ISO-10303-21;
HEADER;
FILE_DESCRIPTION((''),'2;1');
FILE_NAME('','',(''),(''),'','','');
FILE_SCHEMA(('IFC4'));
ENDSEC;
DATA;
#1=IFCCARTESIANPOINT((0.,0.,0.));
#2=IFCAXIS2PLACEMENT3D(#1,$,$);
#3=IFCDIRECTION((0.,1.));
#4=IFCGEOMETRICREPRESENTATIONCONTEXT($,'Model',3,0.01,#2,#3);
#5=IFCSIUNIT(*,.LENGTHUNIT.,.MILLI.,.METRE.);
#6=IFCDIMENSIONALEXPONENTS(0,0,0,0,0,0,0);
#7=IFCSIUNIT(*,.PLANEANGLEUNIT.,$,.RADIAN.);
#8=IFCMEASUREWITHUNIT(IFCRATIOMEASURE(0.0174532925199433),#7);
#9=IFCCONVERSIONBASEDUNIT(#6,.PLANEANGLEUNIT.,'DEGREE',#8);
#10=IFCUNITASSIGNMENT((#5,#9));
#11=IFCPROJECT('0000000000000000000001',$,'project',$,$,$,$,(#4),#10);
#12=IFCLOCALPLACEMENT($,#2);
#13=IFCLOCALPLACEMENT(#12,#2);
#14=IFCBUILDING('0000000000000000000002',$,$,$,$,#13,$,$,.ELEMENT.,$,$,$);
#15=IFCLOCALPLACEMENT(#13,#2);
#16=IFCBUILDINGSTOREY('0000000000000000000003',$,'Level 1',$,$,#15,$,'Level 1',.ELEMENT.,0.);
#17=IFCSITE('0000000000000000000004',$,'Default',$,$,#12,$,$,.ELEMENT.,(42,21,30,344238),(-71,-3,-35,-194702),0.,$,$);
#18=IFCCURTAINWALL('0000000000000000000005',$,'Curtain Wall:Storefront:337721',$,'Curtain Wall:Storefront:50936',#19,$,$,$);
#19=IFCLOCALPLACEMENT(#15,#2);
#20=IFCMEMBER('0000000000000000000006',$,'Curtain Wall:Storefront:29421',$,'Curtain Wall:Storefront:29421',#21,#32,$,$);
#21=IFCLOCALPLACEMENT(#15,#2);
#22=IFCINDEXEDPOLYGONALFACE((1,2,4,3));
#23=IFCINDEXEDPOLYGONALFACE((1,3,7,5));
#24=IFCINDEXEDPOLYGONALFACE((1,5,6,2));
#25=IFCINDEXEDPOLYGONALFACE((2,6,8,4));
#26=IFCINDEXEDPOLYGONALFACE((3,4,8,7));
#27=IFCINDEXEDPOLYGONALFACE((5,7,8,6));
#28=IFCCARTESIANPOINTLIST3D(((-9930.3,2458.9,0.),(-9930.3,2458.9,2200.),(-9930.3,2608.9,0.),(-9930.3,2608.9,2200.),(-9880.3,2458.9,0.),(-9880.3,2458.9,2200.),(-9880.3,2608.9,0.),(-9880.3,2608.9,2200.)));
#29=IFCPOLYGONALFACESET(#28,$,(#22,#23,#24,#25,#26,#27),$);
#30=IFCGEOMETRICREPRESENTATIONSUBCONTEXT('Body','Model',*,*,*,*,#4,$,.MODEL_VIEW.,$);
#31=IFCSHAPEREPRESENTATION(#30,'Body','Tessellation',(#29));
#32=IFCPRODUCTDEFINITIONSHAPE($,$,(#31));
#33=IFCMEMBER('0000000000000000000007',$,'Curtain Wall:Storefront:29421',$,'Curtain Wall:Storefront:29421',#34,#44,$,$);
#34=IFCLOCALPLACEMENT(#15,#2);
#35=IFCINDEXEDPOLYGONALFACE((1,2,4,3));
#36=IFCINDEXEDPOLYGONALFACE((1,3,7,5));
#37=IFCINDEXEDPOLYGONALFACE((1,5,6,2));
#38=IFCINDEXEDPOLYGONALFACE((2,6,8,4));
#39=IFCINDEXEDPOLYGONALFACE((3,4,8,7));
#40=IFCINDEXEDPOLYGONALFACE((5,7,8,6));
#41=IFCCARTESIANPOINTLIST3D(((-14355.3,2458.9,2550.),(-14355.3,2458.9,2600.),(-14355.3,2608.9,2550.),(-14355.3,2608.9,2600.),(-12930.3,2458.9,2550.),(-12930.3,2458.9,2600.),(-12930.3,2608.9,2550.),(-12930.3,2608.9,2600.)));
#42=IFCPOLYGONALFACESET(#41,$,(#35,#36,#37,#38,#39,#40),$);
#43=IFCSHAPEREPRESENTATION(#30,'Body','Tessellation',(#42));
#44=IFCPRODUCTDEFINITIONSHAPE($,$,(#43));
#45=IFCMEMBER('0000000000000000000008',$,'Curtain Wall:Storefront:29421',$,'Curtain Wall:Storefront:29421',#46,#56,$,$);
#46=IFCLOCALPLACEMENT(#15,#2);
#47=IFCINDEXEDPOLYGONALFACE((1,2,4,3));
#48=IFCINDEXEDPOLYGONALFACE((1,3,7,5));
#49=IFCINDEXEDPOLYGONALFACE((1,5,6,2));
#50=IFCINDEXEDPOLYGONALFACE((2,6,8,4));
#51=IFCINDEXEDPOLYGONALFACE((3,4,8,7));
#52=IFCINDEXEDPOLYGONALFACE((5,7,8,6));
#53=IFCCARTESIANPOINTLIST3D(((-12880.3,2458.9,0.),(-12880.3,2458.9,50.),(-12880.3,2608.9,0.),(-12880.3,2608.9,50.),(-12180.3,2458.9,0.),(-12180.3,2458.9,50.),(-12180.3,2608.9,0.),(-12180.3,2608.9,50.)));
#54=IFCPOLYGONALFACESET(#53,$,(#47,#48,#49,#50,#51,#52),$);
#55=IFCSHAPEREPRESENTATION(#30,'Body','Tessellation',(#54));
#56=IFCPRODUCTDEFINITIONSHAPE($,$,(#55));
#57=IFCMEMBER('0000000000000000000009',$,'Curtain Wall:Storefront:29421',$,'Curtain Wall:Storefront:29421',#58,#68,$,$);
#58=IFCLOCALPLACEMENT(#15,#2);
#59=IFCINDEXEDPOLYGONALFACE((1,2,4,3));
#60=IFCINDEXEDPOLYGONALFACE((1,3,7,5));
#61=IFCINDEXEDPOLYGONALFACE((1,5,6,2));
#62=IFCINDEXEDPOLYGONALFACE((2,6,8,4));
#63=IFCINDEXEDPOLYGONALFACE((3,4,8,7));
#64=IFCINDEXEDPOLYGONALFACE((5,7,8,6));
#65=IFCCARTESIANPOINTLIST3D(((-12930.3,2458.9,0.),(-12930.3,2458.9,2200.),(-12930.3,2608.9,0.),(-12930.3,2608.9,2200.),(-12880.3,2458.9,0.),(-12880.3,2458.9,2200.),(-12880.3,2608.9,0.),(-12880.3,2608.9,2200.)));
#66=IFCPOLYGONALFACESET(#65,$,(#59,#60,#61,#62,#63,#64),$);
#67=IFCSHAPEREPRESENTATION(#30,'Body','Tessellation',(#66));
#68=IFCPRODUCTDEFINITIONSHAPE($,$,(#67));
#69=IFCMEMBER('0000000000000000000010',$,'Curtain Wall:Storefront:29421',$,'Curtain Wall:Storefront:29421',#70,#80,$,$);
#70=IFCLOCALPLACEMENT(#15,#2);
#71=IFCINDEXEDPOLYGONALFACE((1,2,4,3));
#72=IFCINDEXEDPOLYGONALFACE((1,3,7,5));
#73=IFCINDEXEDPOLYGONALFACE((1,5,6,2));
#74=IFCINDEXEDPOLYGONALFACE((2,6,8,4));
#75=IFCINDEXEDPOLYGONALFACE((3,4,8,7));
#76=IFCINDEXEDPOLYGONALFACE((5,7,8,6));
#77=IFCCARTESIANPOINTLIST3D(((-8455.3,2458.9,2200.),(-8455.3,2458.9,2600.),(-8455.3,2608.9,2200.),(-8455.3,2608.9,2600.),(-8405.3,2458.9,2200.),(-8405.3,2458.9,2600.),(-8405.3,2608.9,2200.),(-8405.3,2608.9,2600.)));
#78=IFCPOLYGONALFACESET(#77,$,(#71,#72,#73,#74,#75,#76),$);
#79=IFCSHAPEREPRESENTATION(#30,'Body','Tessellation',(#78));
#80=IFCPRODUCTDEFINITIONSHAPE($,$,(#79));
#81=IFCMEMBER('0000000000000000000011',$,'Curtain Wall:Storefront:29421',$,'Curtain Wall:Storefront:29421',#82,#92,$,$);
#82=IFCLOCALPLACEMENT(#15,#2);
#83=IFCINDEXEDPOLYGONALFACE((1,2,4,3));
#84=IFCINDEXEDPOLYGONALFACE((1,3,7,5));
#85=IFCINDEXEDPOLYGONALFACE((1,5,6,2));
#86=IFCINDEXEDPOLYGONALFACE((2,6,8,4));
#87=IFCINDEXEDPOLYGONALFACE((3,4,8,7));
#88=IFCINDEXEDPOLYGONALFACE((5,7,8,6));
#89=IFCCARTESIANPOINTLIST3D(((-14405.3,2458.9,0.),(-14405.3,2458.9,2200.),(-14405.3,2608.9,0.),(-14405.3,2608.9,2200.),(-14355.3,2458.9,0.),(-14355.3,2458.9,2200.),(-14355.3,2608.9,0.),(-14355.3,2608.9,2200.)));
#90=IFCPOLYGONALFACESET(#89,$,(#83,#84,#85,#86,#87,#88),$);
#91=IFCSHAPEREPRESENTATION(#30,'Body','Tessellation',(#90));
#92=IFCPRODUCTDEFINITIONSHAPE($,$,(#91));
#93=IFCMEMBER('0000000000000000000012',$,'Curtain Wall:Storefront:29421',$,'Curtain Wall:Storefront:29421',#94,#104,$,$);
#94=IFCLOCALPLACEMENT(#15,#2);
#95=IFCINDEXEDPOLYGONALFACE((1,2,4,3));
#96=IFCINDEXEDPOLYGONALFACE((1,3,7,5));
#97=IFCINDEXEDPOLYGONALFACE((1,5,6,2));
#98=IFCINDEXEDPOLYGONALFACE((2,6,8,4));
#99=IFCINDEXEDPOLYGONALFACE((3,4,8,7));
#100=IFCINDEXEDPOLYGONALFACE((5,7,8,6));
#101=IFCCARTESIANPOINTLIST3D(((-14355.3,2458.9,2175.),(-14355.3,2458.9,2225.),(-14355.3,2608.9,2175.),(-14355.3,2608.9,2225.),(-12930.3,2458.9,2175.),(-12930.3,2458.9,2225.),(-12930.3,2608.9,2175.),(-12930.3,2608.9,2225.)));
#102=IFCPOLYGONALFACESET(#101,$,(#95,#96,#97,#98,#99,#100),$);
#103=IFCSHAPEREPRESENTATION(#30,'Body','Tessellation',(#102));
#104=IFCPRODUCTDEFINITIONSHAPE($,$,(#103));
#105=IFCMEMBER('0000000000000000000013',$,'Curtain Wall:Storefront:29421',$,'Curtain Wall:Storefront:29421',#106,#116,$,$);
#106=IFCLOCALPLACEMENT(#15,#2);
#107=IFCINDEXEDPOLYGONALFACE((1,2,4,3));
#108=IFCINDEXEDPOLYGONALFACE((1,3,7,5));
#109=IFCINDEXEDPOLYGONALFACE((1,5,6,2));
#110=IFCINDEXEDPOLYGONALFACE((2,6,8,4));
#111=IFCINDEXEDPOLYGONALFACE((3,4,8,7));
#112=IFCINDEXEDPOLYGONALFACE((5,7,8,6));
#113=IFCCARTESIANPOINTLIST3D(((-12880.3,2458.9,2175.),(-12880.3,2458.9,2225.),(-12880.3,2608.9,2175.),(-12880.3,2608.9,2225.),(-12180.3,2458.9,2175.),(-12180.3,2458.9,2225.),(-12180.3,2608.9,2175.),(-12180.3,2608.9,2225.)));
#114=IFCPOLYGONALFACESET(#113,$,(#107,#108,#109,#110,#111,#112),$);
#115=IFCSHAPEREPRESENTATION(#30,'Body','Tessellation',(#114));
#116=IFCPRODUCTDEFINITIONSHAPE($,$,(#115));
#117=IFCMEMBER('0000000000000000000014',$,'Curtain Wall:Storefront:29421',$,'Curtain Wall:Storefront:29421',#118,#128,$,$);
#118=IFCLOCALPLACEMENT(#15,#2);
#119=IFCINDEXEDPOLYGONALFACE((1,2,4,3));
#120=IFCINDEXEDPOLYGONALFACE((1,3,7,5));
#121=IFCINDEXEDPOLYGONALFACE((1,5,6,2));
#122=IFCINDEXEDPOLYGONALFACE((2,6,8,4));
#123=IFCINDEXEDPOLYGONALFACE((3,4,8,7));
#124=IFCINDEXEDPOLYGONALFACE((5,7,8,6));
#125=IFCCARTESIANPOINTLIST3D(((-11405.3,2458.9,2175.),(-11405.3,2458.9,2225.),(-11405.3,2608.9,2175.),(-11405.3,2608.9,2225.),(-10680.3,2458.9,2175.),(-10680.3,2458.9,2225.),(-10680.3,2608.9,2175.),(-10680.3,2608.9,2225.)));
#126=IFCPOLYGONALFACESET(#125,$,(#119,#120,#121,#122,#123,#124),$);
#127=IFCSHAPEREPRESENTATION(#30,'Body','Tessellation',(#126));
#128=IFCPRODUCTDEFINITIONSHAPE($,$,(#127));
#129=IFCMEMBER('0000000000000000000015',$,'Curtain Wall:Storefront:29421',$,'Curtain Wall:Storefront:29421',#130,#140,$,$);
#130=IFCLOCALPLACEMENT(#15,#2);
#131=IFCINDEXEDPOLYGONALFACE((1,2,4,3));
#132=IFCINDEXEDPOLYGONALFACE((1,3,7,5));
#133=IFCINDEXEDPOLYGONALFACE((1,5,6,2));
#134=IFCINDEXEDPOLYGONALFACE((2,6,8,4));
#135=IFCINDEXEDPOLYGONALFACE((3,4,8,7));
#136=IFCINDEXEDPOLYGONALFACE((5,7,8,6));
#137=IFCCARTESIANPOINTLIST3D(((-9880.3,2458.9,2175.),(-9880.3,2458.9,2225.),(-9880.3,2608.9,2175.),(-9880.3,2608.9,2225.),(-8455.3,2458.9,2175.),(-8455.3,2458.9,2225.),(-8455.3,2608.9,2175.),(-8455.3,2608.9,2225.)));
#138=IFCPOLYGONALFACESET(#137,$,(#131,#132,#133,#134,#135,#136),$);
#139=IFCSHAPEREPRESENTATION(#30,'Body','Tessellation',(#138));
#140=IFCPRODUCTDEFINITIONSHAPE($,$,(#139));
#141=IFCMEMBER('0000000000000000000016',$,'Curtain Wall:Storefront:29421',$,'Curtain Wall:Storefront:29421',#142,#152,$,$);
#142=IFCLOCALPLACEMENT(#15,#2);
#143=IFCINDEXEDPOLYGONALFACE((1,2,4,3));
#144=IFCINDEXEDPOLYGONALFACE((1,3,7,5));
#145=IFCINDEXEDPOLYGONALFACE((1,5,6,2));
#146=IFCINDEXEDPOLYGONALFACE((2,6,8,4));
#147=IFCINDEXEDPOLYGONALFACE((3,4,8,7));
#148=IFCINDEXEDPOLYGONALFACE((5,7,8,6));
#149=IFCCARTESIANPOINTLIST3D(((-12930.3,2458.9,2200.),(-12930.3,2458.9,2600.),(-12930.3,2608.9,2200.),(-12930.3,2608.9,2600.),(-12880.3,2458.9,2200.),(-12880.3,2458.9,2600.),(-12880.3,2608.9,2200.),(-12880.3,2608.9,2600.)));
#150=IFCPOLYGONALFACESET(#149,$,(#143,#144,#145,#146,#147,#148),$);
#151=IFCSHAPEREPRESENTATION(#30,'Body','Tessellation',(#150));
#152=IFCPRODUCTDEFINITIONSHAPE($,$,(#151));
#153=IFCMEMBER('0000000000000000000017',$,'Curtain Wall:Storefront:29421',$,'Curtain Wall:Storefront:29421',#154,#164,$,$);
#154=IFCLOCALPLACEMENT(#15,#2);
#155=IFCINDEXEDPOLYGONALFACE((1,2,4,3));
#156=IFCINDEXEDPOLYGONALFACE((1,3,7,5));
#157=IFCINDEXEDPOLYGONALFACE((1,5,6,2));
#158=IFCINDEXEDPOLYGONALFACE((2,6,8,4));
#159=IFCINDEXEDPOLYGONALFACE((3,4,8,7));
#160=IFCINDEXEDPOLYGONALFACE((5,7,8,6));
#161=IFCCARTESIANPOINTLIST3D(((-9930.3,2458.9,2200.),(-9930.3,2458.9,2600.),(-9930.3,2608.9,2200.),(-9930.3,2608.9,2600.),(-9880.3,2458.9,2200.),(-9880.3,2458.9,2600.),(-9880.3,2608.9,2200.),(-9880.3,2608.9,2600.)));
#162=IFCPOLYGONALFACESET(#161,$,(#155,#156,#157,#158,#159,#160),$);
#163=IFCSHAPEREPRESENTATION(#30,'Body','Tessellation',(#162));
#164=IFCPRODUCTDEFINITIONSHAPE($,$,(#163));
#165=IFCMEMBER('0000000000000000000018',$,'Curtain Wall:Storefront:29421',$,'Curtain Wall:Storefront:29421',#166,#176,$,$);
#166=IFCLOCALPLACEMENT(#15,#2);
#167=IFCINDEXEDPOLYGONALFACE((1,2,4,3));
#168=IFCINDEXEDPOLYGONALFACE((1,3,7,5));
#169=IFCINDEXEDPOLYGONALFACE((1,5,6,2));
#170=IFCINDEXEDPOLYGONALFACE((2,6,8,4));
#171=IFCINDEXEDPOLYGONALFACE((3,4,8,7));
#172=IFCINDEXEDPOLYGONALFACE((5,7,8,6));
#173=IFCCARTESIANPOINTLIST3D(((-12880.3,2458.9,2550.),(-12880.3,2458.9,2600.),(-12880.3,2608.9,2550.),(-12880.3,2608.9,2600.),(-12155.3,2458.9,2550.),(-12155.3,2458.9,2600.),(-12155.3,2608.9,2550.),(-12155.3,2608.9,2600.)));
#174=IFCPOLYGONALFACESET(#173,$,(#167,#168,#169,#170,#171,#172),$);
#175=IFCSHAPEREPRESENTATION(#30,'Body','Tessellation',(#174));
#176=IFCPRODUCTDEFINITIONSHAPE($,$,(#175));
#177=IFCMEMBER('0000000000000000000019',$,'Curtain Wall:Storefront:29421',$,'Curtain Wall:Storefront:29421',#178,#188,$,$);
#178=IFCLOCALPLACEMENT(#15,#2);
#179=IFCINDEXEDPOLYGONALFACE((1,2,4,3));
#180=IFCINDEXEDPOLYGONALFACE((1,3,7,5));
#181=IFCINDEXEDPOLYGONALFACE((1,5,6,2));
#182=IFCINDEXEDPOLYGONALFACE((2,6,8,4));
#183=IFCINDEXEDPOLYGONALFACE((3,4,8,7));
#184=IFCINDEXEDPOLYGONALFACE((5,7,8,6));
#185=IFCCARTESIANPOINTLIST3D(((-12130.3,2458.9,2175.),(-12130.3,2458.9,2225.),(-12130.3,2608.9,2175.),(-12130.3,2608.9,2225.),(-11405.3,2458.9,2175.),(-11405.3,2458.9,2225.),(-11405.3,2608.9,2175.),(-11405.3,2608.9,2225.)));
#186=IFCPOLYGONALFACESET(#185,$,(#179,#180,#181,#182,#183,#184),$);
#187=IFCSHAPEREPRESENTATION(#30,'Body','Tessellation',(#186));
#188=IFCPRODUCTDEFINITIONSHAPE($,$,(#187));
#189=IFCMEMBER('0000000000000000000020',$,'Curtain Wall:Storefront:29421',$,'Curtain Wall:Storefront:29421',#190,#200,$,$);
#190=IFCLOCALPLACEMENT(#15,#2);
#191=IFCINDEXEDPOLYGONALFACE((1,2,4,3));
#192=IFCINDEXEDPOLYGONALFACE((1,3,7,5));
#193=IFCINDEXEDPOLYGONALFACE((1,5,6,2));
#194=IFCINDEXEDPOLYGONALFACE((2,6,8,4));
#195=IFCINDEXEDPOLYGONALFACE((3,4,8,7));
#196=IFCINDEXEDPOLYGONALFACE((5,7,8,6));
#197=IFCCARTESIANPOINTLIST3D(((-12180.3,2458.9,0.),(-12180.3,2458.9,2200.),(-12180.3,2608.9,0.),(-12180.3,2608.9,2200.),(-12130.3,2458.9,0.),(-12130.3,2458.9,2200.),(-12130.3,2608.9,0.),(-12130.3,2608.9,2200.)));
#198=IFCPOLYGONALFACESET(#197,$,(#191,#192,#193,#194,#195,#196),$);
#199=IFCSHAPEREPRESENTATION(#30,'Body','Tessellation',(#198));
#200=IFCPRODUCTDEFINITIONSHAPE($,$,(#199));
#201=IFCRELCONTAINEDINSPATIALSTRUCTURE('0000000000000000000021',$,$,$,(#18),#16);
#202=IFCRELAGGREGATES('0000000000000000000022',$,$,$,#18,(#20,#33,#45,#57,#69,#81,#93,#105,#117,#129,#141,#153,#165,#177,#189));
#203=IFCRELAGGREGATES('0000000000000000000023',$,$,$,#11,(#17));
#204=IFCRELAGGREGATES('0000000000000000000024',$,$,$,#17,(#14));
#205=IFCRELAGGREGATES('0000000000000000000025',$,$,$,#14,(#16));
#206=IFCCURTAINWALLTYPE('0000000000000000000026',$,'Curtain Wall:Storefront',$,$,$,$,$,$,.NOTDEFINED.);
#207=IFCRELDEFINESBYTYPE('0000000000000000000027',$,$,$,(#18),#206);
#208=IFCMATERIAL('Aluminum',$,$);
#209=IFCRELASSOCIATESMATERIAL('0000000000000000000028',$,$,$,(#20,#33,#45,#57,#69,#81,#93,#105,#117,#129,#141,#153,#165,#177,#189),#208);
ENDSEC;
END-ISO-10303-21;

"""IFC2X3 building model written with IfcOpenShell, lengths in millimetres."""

from ifc_helpers import new_model, entity, si_unit, converted_unit, direction, frame, frame_2d, origin, origin_2d_with_axis, place, context, subcontext, project, spatial, rectangle, extrude, material, type_object, element, aggregate, save


model = new_model("IFC2X3")

# Units and contexts
model_context = context("Model", 3, precision=0.01, world=origin(), true_north=direction((0.0, 1.0)))
body_context = subcontext(model_context, "Body", "Model", "MODEL_VIEW")
ifc_project = project(units=[si_unit("LENGTHUNIT", "METRE", prefix="MILLI"), converted_unit("PLANEANGLEUNIT", "DEGREE", entity("IfcRatioMeasure", 0.0174532925199433), si_unit("PLANEANGLEUNIT", "RADIAN"), dimensions=[0, 0, 0, 0, 0, 0, 0])], contexts=[model_context])

# Site, building, storey
site_placement = place(None, origin())
site = spatial("IfcSite", under=ifc_project, at=site_placement, Name="Default", CompositionType="ELEMENT", RefLatitude=(42, 21, 30, 344238), RefLongitude=(-71, -3, -35, -194702), RefElevation=0.0)
building_placement = place(site_placement, origin())
building = spatial("IfcBuilding", under=site, at=building_placement, CompositionType="ELEMENT")
storey_placement = place(building_placement, origin())
storey = spatial("IfcBuildingStorey", under=building, at=storey_placement, Name="Level 1", LongName="Level 1", CompositionType="ELEMENT", Elevation=0.0)

# Curtain wall, members
curtain_wall_type = type_object("IfcCurtainWallType", Name="Curtain Wall:Storefront", PredefinedType="NOTDEFINED")
curtain_wall_placement = place(storey_placement, origin())
curtain_wall = element("IfcCurtainWall", 1, at=curtain_wall_placement, inside=storey, type_object=curtain_wall_type, Name="Curtain Wall:Storefront:337721", ObjectType="Curtain Wall:Storefront:50936")
ifc_material = material(Name="Aluminum")
member_1_placement = place(curtain_wall_placement, origin())
member_1 = element("IfcMember", 2, at=member_1_placement, material=ifc_material, Name="Curtain Wall:Storefront:29421", ObjectType="Curtain Wall:Storefront:29421", context=body_context, shape_type="SweptSolid", body=[
    extrude(rectangle(XDim=50.0, YDim=150.0, at=origin_2d_with_axis()), frame((-9905.3, 2533.9, 0.0), z_axis=(0.0, 0.0, 1.0), x_axis=(-1.0, 0.0, 0.0)), (0.0, 0.0, 1.0), 2200.0),
])
member_2_placement = place(curtain_wall_placement, origin())
member_2 = element("IfcMember", 3, at=member_2_placement, material=ifc_material, Name="Curtain Wall:Storefront:29421", ObjectType="Curtain Wall:Storefront:29421", context=body_context, shape_type="SweptSolid", body=[
    extrude(rectangle(XDim=50.0, YDim=150.0, at=frame_2d((0.0, 0.0), x_axis=(1.0, 0.0))), frame((-12930.3, 2533.9, 2575.0), z_axis=(-1.0, 0.0, 0.0), x_axis=(0.0, 0.0, -1.0)), (0.0, 0.0, 1.0), 1425.0),
])
member_3_placement = place(curtain_wall_placement, origin())
member_3 = element("IfcMember", 4, at=member_3_placement, material=ifc_material, Name="Curtain Wall:Storefront:29421", ObjectType="Curtain Wall:Storefront:29421", context=body_context, shape_type="SweptSolid", body=[
    extrude(rectangle(XDim=50.0, YDim=150.0, at=frame_2d((0.0, 0.0), x_axis=(1.0, 0.0))), frame((-12880.3, 2533.9, 25.0), z_axis=(1.0, 0.0, 0.0), x_axis=(0.0, 0.0, -1.0)), (0.0, 0.0, 1.0), 700.0),
])
member_4_placement = place(curtain_wall_placement, origin())
member_4 = element("IfcMember", 5, at=member_4_placement, material=ifc_material, Name="Curtain Wall:Storefront:29421", ObjectType="Curtain Wall:Storefront:29421", context=body_context, shape_type="SweptSolid", body=[
    extrude(rectangle(XDim=50.0, YDim=150.0, at=origin_2d_with_axis()), frame((-12905.3, 2533.9, 0.0), z_axis=(0.0, 0.0, 1.0), x_axis=(-1.0, 0.0, 0.0)), (0.0, 0.0, 1.0), 2200.0),
])
member_5_placement = place(curtain_wall_placement, origin())
member_5 = element("IfcMember", 6, at=member_5_placement, material=ifc_material, Name="Curtain Wall:Storefront:29421", ObjectType="Curtain Wall:Storefront:29421", context=body_context, shape_type="SweptSolid", body=[
    extrude(rectangle(XDim=50.0, YDim=150.0, at=origin_2d_with_axis()), frame((-8430.3, 2533.9, 2200.0), z_axis=(0.0, 0.0, 1.0), x_axis=(-1.0, 0.0, 0.0)), (0.0, 0.0, 1.0), 400.0),
])
member_6_placement = place(curtain_wall_placement, origin())
member_6 = element("IfcMember", 7, at=member_6_placement, material=ifc_material, Name="Curtain Wall:Storefront:29421", ObjectType="Curtain Wall:Storefront:29421", context=body_context, shape_type="SweptSolid", body=[
    extrude(rectangle(XDim=50.0, YDim=150.0, at=frame_2d((0.0, 0.0), x_axis=(1.0, 0.0))), frame((-14380.3, 2533.9, 2200.0), z_axis=(0.0, 0.0, -1.0), x_axis=(-1.0, 0.0, 0.0)), (0.0, 0.0, 1.0), 2200.0),
])
member_7_placement = place(curtain_wall_placement, origin())
member_7 = element("IfcMember", 8, at=member_7_placement, material=ifc_material, Name="Curtain Wall:Storefront:29421", ObjectType="Curtain Wall:Storefront:29421", context=body_context, shape_type="SweptSolid", body=[
    extrude(rectangle(XDim=50.0, YDim=150.0, at=frame_2d((0.0, 0.0), x_axis=(1.0, 0.0))), frame((-12930.3, 2533.9, 2200.0), z_axis=(-1.0, 0.0, 0.0), x_axis=(0.0, 0.0, -1.0)), (0.0, 0.0, 1.0), 1425.0),
])
member_8_placement = place(curtain_wall_placement, origin())
member_8 = element("IfcMember", 9, at=member_8_placement, material=ifc_material, Name="Curtain Wall:Storefront:29421", ObjectType="Curtain Wall:Storefront:29421", context=body_context, shape_type="SweptSolid", body=[
    extrude(rectangle(XDim=50.0, YDim=150.0, at=frame_2d((0.0, 0.0), x_axis=(1.0, 0.0))), frame((-12180.3, 2533.9, 2200.0), z_axis=(-1.0, 0.0, 0.0), x_axis=(0.0, 0.0, -1.0)), (0.0, 0.0, 1.0), 700.0),
])
member_9_placement = place(curtain_wall_placement, origin())
member_9 = element("IfcMember", 10, at=member_9_placement, material=ifc_material, Name="Curtain Wall:Storefront:29421", ObjectType="Curtain Wall:Storefront:29421", context=body_context, shape_type="SweptSolid", body=[
    extrude(rectangle(XDim=50.0, YDim=150.0, at=frame_2d((0.0, 0.0), x_axis=(1.0, 0.0))), frame((-10680.3, 2533.9, 2200.0), z_axis=(-1.0, 0.0, 0.0), x_axis=(0.0, 0.0, -1.0)), (0.0, 0.0, 1.0), 725.0),
])
member_10_placement = place(curtain_wall_placement, origin())
member_10 = element("IfcMember", 11, at=member_10_placement, material=ifc_material, Name="Curtain Wall:Storefront:29421", ObjectType="Curtain Wall:Storefront:29421", context=body_context, shape_type="SweptSolid", body=[
    extrude(rectangle(XDim=50.0, YDim=150.0, at=frame_2d((0.0, 0.0), x_axis=(1.0, 0.0))), frame((-8455.3, 2533.9, 2200.0), z_axis=(-1.0, 0.0, 0.0), x_axis=(0.0, 0.0, -1.0)), (0.0, 0.0, 1.0), 1425.0),
])
member_11_placement = place(curtain_wall_placement, origin())
member_11 = element("IfcMember", 12, at=member_11_placement, material=ifc_material, Name="Curtain Wall:Storefront:29421", ObjectType="Curtain Wall:Storefront:29421", context=body_context, shape_type="SweptSolid", body=[
    extrude(rectangle(XDim=50.0, YDim=150.0, at=origin_2d_with_axis()), frame((-12905.3, 2533.9, 2200.0), z_axis=(0.0, 0.0, 1.0), x_axis=(-1.0, 0.0, 0.0)), (0.0, 0.0, 1.0), 400.0),
])
member_12_placement = place(curtain_wall_placement, origin())
member_12 = element("IfcMember", 13, at=member_12_placement, material=ifc_material, Name="Curtain Wall:Storefront:29421", ObjectType="Curtain Wall:Storefront:29421", context=body_context, shape_type="SweptSolid", body=[
    extrude(rectangle(XDim=50.0, YDim=150.0, at=origin_2d_with_axis()), frame((-9905.3, 2533.9, 2200.0), z_axis=(0.0, 0.0, 1.0), x_axis=(-1.0, 0.0, 0.0)), (0.0, 0.0, 1.0), 400.0),
])
member_13_placement = place(curtain_wall_placement, origin())
member_13 = element("IfcMember", 14, at=member_13_placement, material=ifc_material, Name="Curtain Wall:Storefront:29421", ObjectType="Curtain Wall:Storefront:29421", context=body_context, shape_type="SweptSolid", body=[
    extrude(rectangle(XDim=50.0, YDim=150.0, at=frame_2d((0.0, 0.0), x_axis=(1.0, 0.0))), frame((-12155.3, 2533.9, 2575.0), z_axis=(-1.0, 0.0, 0.0), x_axis=(0.0, 0.0, -1.0)), (0.0, 0.0, 1.0), 725.0),
])
member_14_placement = place(curtain_wall_placement, origin())
member_14 = element("IfcMember", 15, at=member_14_placement, material=ifc_material, Name="Curtain Wall:Storefront:29421", ObjectType="Curtain Wall:Storefront:29421", context=body_context, shape_type="SweptSolid", body=[
    extrude(rectangle(XDim=50.0, YDim=150.0, at=frame_2d((0.0, 0.0), x_axis=(1.0, 0.0))), frame((-11405.3, 2533.9, 2200.0), z_axis=(-1.0, 0.0, 0.0), x_axis=(0.0, 0.0, -1.0)), (0.0, 0.0, 1.0), 725.0),
])
member_15_placement = place(curtain_wall_placement, origin())
member_15 = element("IfcMember", 16, at=member_15_placement, material=ifc_material, Name="Curtain Wall:Storefront:29421", ObjectType="Curtain Wall:Storefront:29421", context=body_context, shape_type="SweptSolid", body=[
    extrude(rectangle(XDim=50.0, YDim=150.0, at=frame_2d((0.0, 0.0), x_axis=(1.0, 0.0))), frame((-12155.3, 2533.9, 0.0), z_axis=(0.0, 0.0, 1.0), x_axis=(-1.0, 0.0, 0.0)), (0.0, 0.0, 1.0), 2200.0),
])
aggregate(curtain_wall, [member_1, member_2, member_3, member_4, member_5, member_6, member_7, member_8, member_9, member_10, member_11, member_12, member_13, member_14, member_15])

save(model, "model.ifc")
